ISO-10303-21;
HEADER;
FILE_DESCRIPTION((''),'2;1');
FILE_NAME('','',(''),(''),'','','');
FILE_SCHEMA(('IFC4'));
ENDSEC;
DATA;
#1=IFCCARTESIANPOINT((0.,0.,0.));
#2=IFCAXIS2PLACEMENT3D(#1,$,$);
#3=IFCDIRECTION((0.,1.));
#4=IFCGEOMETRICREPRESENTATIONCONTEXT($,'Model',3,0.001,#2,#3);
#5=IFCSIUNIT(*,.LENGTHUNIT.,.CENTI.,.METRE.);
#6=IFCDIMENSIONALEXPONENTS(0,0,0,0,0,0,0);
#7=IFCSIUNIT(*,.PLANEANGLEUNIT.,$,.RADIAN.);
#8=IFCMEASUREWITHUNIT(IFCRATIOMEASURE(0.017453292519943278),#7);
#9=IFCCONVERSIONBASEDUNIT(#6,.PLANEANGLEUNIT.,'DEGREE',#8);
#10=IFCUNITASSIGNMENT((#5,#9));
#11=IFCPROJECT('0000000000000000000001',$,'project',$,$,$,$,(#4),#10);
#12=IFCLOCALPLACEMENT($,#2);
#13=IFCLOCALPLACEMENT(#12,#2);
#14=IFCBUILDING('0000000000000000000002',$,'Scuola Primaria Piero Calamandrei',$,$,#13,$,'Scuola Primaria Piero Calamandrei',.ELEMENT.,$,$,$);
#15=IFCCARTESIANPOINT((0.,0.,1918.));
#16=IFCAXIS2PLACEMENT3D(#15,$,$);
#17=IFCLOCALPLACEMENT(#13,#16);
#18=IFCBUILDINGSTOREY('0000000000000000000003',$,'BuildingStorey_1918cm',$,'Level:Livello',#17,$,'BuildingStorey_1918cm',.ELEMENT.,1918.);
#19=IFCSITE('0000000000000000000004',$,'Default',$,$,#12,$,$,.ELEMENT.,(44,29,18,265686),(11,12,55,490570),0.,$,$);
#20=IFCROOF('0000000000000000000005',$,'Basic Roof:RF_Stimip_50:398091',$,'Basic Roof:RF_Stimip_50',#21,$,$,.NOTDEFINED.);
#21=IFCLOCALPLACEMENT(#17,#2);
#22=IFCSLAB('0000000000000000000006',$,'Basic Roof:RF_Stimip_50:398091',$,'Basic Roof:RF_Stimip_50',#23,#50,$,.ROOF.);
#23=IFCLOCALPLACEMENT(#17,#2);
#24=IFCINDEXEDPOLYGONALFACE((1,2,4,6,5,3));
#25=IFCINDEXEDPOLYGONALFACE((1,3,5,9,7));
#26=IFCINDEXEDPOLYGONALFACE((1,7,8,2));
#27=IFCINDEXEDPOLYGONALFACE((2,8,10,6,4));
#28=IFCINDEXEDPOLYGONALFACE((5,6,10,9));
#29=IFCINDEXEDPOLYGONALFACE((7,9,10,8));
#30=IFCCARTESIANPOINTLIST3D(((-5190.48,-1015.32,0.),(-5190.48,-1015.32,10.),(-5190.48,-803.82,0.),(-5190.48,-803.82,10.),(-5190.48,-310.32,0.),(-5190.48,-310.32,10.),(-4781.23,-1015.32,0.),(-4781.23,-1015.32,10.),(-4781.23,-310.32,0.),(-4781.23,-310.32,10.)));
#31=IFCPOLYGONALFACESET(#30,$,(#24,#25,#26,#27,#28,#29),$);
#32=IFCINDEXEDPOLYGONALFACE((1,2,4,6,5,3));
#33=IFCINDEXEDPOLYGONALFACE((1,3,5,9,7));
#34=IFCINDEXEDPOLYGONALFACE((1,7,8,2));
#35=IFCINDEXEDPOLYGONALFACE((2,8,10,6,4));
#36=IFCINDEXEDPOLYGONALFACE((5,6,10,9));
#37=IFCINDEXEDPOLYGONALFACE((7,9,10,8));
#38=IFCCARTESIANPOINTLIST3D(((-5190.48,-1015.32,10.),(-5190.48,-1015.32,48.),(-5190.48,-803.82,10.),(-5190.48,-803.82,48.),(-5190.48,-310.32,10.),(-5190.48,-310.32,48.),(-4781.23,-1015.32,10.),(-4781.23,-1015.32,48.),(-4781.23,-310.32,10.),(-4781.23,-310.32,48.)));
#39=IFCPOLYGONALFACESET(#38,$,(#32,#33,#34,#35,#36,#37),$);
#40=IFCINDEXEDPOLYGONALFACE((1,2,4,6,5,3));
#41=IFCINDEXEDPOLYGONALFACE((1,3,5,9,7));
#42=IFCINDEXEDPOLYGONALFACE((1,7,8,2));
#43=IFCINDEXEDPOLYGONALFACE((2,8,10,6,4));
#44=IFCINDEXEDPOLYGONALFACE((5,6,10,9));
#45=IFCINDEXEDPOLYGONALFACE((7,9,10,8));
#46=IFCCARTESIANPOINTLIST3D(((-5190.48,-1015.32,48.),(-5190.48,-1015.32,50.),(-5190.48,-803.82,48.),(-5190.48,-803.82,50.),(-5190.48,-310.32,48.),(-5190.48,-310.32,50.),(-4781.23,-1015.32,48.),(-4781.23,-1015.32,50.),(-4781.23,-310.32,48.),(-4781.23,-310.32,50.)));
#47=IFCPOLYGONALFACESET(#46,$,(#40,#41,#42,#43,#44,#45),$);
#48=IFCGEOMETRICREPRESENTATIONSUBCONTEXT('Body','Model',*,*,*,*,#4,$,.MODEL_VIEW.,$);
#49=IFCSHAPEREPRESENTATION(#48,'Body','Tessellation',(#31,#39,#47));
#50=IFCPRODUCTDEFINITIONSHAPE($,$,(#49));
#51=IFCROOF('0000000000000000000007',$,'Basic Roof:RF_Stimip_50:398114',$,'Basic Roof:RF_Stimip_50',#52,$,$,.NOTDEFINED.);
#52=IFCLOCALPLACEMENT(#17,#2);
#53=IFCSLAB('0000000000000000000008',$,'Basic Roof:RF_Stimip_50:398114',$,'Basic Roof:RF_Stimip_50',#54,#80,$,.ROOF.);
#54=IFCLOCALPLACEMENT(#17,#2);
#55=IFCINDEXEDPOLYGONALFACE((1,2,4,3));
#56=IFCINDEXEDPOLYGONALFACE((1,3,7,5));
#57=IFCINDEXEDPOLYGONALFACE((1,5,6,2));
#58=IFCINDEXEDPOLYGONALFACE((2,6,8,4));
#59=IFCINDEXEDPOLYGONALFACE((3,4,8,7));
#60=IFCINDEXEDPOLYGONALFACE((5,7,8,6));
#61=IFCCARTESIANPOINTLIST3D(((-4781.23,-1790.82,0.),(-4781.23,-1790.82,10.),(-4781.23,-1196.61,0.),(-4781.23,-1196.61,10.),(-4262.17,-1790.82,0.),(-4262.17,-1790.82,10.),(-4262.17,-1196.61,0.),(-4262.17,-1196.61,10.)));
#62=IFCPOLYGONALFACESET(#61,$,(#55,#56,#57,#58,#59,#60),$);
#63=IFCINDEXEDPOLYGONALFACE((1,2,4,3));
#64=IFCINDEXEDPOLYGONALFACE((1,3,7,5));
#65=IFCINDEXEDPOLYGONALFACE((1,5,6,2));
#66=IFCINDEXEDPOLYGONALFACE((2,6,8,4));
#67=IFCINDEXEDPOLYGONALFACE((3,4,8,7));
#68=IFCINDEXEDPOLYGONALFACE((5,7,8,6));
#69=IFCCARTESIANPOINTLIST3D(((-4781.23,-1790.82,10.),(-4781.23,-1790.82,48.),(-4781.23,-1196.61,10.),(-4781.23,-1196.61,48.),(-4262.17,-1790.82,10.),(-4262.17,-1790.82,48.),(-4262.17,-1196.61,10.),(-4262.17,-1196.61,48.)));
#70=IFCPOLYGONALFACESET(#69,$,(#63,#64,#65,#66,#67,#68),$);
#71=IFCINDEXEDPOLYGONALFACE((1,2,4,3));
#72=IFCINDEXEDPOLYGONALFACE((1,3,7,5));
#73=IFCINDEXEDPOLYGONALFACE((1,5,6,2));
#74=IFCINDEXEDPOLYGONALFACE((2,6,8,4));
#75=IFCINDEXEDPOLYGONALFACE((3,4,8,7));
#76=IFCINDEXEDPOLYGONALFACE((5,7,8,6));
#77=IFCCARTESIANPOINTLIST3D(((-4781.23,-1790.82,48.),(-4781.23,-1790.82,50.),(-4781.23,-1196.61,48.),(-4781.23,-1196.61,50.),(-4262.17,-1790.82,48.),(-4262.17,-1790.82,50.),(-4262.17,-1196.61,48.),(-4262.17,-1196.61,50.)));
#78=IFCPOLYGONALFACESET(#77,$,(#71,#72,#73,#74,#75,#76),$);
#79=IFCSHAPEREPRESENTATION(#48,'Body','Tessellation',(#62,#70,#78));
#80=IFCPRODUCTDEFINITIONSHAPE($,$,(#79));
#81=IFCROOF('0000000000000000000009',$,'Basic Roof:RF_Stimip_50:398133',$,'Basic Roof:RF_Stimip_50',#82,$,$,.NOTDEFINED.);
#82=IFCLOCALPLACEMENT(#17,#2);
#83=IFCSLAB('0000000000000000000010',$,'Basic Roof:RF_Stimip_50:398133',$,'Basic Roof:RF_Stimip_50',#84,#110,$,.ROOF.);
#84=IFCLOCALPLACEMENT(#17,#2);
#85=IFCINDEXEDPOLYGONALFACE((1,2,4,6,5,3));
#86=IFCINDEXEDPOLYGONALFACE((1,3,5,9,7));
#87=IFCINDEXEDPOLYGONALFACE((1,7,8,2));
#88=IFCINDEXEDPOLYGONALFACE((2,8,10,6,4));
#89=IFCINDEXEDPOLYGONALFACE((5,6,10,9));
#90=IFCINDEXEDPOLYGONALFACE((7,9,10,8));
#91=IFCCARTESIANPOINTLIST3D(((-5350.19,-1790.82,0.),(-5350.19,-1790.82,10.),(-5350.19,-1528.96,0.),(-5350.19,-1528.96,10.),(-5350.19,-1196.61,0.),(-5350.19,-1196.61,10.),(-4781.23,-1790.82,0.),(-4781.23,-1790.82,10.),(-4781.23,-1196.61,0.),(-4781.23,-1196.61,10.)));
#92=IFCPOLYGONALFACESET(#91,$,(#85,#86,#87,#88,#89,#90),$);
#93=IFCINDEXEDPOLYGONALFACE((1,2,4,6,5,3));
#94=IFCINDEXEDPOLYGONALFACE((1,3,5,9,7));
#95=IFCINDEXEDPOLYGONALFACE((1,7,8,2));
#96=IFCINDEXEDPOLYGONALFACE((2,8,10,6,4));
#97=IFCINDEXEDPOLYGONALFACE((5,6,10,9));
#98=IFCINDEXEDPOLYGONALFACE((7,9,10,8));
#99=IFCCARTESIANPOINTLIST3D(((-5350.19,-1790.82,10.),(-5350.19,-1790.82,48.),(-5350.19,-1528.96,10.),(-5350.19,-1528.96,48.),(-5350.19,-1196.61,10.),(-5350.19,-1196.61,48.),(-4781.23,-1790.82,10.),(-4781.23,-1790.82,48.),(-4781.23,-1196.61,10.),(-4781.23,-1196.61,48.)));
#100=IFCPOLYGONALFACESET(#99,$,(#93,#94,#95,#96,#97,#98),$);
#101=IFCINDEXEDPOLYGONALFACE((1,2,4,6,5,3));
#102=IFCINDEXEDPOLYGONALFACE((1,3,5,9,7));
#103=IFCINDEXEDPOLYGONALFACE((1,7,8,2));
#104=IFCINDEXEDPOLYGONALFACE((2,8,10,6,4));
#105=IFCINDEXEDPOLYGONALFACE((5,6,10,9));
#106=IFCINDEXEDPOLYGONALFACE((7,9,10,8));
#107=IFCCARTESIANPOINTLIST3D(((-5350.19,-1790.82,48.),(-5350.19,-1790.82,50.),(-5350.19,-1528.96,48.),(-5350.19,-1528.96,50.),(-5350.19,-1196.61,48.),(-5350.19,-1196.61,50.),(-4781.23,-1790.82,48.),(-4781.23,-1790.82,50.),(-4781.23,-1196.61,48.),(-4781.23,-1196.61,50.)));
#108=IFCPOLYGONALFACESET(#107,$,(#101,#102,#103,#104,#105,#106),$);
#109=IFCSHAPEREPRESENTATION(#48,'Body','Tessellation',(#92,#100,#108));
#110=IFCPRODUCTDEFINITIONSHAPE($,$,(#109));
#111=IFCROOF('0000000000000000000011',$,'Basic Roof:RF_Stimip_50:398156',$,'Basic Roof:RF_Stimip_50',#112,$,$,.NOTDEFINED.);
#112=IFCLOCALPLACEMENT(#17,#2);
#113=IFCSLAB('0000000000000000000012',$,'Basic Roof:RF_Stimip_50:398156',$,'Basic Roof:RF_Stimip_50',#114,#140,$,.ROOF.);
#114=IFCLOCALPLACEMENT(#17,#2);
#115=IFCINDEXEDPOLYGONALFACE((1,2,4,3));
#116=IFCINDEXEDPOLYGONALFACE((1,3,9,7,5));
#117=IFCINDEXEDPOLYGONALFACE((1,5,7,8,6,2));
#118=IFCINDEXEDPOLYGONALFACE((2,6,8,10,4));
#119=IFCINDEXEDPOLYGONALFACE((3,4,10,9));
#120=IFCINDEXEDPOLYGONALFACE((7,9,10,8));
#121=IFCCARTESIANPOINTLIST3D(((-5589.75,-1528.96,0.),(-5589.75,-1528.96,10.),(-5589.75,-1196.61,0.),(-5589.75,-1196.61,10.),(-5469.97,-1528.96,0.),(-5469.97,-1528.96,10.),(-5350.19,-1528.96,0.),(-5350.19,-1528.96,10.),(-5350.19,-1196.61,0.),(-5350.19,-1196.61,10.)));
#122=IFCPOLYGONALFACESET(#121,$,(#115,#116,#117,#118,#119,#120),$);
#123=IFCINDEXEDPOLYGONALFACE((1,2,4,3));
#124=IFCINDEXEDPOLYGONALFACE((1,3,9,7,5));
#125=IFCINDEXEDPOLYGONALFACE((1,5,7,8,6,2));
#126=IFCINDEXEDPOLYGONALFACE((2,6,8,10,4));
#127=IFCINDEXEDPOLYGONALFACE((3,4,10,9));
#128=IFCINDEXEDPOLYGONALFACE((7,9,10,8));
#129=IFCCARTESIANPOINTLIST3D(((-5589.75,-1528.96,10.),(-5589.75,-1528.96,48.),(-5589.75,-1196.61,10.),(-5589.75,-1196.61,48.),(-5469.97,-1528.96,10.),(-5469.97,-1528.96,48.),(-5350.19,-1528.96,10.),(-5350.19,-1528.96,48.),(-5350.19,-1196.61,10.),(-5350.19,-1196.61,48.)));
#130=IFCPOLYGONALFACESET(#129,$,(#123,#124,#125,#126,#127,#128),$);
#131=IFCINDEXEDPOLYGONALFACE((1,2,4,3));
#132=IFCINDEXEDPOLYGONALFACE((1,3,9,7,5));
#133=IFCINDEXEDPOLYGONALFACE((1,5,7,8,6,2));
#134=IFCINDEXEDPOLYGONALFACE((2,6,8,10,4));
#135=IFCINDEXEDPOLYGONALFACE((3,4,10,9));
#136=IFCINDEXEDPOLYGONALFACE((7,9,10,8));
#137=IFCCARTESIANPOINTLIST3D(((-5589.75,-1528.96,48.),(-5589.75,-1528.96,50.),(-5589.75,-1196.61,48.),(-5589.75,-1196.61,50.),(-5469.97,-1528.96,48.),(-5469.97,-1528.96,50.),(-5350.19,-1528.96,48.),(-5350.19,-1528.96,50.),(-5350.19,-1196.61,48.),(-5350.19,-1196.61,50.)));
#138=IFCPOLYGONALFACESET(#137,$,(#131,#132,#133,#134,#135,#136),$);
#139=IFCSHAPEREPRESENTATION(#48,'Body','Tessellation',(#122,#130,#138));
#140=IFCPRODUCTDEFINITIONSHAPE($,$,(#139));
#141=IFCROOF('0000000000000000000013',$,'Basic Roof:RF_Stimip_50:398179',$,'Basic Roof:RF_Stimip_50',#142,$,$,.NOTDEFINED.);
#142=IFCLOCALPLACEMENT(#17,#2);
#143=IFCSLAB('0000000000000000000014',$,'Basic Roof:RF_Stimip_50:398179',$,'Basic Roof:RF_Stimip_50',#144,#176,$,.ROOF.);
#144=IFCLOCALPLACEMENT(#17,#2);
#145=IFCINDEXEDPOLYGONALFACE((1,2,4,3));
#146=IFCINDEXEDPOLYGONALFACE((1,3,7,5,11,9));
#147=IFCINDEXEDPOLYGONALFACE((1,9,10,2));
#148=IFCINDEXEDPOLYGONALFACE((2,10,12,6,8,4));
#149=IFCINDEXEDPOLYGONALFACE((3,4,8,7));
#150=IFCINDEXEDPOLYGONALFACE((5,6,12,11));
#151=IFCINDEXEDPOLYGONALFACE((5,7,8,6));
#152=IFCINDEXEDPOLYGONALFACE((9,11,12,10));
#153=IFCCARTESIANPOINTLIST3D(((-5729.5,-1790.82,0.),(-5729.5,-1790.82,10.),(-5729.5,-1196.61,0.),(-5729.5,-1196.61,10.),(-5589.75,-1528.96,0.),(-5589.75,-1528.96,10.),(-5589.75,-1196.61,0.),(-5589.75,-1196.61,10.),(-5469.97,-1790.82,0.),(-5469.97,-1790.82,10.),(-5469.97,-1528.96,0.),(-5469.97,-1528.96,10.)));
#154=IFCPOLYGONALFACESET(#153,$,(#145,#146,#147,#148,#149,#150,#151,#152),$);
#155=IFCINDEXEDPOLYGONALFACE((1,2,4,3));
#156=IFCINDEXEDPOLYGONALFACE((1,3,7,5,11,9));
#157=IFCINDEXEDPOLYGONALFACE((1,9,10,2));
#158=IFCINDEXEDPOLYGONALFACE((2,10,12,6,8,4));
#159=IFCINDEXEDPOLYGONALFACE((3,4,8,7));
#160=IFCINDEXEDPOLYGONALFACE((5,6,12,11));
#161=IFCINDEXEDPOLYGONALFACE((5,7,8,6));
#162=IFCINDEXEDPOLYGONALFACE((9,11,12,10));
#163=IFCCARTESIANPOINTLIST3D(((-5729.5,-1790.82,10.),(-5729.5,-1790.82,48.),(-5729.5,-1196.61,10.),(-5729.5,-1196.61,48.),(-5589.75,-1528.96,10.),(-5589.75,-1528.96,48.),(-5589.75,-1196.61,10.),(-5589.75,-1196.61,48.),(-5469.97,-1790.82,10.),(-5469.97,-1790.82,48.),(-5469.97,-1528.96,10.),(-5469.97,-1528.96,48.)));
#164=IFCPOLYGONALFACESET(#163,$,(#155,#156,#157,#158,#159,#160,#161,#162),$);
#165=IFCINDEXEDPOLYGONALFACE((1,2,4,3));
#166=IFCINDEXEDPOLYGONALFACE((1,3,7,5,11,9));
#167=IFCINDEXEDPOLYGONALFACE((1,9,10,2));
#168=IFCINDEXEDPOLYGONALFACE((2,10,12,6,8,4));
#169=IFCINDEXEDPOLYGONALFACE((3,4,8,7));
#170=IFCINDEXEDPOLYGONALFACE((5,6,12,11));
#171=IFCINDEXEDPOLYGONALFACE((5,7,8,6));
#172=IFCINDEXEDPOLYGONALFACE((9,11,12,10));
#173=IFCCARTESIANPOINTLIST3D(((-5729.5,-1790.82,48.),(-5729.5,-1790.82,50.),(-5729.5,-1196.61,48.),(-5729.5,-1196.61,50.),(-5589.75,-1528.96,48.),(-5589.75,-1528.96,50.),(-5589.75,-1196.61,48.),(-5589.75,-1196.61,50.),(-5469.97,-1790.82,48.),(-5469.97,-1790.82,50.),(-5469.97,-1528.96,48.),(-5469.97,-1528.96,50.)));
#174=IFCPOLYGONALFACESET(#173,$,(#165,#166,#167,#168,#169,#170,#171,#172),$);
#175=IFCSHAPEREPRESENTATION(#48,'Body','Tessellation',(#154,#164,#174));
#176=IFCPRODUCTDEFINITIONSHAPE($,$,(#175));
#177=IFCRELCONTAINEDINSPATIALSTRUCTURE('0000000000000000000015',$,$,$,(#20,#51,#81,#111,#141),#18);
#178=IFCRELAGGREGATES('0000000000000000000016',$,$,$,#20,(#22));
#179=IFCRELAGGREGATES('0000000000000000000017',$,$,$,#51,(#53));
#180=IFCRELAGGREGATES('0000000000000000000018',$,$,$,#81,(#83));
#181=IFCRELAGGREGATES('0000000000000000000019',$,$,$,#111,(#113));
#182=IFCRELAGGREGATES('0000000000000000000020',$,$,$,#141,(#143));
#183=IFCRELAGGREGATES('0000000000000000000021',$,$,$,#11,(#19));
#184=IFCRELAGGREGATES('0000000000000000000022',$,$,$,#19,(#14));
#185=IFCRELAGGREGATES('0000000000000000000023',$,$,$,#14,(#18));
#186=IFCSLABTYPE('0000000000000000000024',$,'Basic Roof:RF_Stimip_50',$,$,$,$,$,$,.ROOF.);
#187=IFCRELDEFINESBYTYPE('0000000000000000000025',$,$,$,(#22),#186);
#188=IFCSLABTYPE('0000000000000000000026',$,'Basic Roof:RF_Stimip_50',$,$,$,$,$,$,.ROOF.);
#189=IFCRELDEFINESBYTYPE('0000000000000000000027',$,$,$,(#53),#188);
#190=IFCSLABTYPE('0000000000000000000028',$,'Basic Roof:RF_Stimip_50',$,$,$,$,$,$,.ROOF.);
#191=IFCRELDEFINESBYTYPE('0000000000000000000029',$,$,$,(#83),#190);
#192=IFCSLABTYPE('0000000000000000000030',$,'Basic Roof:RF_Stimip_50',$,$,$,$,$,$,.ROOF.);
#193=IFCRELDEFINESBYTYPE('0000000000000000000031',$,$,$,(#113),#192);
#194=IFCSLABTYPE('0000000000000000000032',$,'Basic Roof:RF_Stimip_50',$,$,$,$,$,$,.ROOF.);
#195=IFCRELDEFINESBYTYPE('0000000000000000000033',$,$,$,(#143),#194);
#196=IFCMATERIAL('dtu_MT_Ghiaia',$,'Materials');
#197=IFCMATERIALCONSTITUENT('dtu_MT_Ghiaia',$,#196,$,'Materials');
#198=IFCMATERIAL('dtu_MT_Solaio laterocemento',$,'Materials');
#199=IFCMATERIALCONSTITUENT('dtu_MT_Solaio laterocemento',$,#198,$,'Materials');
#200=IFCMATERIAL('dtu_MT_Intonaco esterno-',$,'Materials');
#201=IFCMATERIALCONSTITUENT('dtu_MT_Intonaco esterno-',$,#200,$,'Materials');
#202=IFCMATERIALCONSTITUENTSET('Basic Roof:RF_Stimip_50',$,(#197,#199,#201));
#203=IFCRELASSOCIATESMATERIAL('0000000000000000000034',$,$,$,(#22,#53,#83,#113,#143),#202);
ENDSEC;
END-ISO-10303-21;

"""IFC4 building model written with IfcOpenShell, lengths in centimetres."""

from ifc_helpers import new_model, entity, si_unit, converted_unit, direction, frame, origin, place, context, subcontext, project, spatial, indexed_curve, outline, extrude, material, constituent, constituent_set, type_object, element, aggregate, save


model = new_model("IFC4")

# Units and contexts
model_context = context("Model", 3, precision=0.001, world=origin(), true_north=direction((0.0, 1.0)))
body_context = subcontext(model_context, "Body", "Model", "MODEL_VIEW")
ifc_project = project(units=[si_unit("LENGTHUNIT", "METRE", prefix="CENTI"), converted_unit("PLANEANGLEUNIT", "DEGREE", entity("IfcRatioMeasure", 0.017453292519943278), si_unit("PLANEANGLEUNIT", "RADIAN"), dimensions=[0, 0, 0, 0, 0, 0, 0])], contexts=[model_context])

# Site, building, storey
site_placement = place(None, origin())
site = spatial("IfcSite", under=ifc_project, at=site_placement, Name="Default", CompositionType="ELEMENT", RefLatitude=(44, 29, 18, 265686), RefLongitude=(11, 12, 55, 490570), RefElevation=0.0)
building_placement = place(site_placement, origin())
building = spatial("IfcBuilding", under=site, at=building_placement, Name="Scuola Primaria Piero Calamandrei", LongName="Scuola Primaria Piero Calamandrei", CompositionType="ELEMENT")
storey_placement = place(building_placement, frame((0.0, 0.0, 1918.0)))
storey = spatial("IfcBuildingStorey", under=building, at=storey_placement, Name="BuildingStorey_1918cm", ObjectType="Level:Livello", LongName="BuildingStorey_1918cm", CompositionType="ELEMENT", Elevation=1918.0)

# Roofs, slabs
ifc_material_1 = material(Name="dtu_MT_Ghiaia", Category="Materials")
ifc_constituent_1 = constituent(ifc_material_1, Name="dtu_MT_Ghiaia", Category="Materials")
ifc_material_2 = material(Name="dtu_MT_Solaio laterocemento", Category="Materials")
ifc_constituent_2 = constituent(ifc_material_2, Name="dtu_MT_Solaio laterocemento", Category="Materials")
ifc_material_3 = material(Name="dtu_MT_Intonaco esterno-", Category="Materials")
ifc_constituent_3 = constituent(ifc_material_3, Name="dtu_MT_Intonaco esterno-", Category="Materials")
ifc_constituent_set = constituent_set(constituents=[ifc_constituent_1, ifc_constituent_2, ifc_constituent_3], Name="Basic Roof:RF_Stimip_50")
roof_1_placement = place(storey_placement, frame((-5190.48, -1015.32, 0.0)))
roof_1 = element("IfcRoof", 1, at=roof_1_placement, inside=storey, Name="Basic Roof:RF_Stimip_50:398091", ObjectType="Basic Roof:RF_Stimip_50", PredefinedType="NOTDEFINED")
slab_type_1 = type_object("IfcSlabType", Name="Basic Roof:RF_Stimip_50", PredefinedType="ROOF")
slab_1_placement = place(roof_1_placement, origin())
slab_1 = element("IfcSlab", 2, at=slab_1_placement, type_object=slab_type_1, material=ifc_constituent_set, Name="Basic Roof:RF_Stimip_50:398091", ObjectType="Basic Roof:RF_Stimip_50", PredefinedType="ROOF", context=body_context, shape_type="SweptSolid", body=[
    extrude(outline(indexed_curve([(-204.63, -141.0), (-204.63, -352.5), (204.63, -352.5), (204.63, 352.5), (-204.63, 352.5), (-204.63, -141.0)], self_intersect=False)), frame((204.63, 352.5, 0.0)), (0.0, 0.0, 1.0), 10.0),
    extrude(outline(indexed_curve([(-204.63, -141.0), (-204.63, -352.5), (204.63, -352.5), (204.63, 352.5), (-204.63, 352.5), (-204.63, -141.0)], self_intersect=False)), frame((204.63, 352.5, 10.0)), (0.0, 0.0, 1.0), 38.0),
    extrude(outline(indexed_curve([(-204.63, -141.0), (-204.63, -352.5), (204.63, -352.5), (204.63, 352.5), (-204.63, 352.5), (-204.63, -141.0)], self_intersect=False)), frame((204.63, 352.5, 48.0)), (0.0, 0.0, 1.0), 2.0),
])
aggregate(roof_1, [slab_1])
roof_2_placement = place(storey_placement, frame((-4781.23, -1790.82, 0.0)))
roof_2 = element("IfcRoof", 3, at=roof_2_placement, inside=storey, Name="Basic Roof:RF_Stimip_50:398114", ObjectType="Basic Roof:RF_Stimip_50", PredefinedType="NOTDEFINED")
slab_type_2 = type_object("IfcSlabType", Name="Basic Roof:RF_Stimip_50", PredefinedType="ROOF")
slab_2_placement = place(roof_2_placement, origin())
slab_2 = element("IfcSlab", 4, at=slab_2_placement, type_object=slab_type_2, material=ifc_constituent_set, Name="Basic Roof:RF_Stimip_50:398114", ObjectType="Basic Roof:RF_Stimip_50", PredefinedType="ROOF", context=body_context, shape_type="SweptSolid", body=[
    extrude(outline(indexed_curve([(-259.53, -297.11), (259.53, -297.11), (259.53, 297.11), (-259.53, 297.11), (-259.53, -297.11)], self_intersect=False)), frame((259.53, 297.11, 0.0)), (0.0, 0.0, 1.0), 10.0),
    extrude(outline(indexed_curve([(-259.53, -297.11), (259.53, -297.11), (259.53, 297.11), (-259.53, 297.11), (-259.53, -297.11)], self_intersect=False)), frame((259.53, 297.11, 10.0)), (0.0, 0.0, 1.0), 38.0),
    extrude(outline(indexed_curve([(-259.53, -297.11), (259.53, -297.11), (259.53, 297.11), (-259.53, 297.11), (-259.53, -297.11)], self_intersect=False)), frame((259.53, 297.11, 48.0)), (0.0, 0.0, 1.0), 2.0),
])
aggregate(roof_2, [slab_2])
roof_3_placement = place(storey_placement, frame((-5350.19, -1790.82, 0.0)))
roof_3 = element("IfcRoof", 5, at=roof_3_placement, inside=storey, Name="Basic Roof:RF_Stimip_50:398133", ObjectType="Basic Roof:RF_Stimip_50", PredefinedType="NOTDEFINED")
slab_type_3 = type_object("IfcSlabType", Name="Basic Roof:RF_Stimip_50", PredefinedType="ROOF")
slab_3_placement = place(roof_3_placement, origin())
slab_3 = element("IfcSlab", 6, at=slab_3_placement, type_object=slab_type_3, material=ifc_constituent_set, Name="Basic Roof:RF_Stimip_50:398133", ObjectType="Basic Roof:RF_Stimip_50", PredefinedType="ROOF", context=body_context, shape_type="SweptSolid", body=[
    extrude(outline(indexed_curve([(-284.48, -297.11), (284.48, -297.11), (284.48, 297.11), (-284.48, 297.11), (-284.48, -35.25), (-284.48, -297.11)], self_intersect=False)), frame((284.48, 297.11, 0.0)), (0.0, 0.0, 1.0), 10.0),
    extrude(outline(indexed_curve([(-284.48, -297.11), (284.48, -297.11), (284.48, 297.11), (-284.48, 297.11), (-284.48, -35.25), (-284.48, -297.11)], self_intersect=False)), frame((284.48, 297.11, 10.0)), (0.0, 0.0, 1.0), 38.0),
    extrude(outline(indexed_curve([(-284.48, -297.11), (284.48, -297.11), (284.48, 297.11), (-284.48, 297.11), (-284.48, -35.25), (-284.48, -297.11)], self_intersect=False)), frame((284.48, 297.11, 48.0)), (0.0, 0.0, 1.0), 2.0),
])
aggregate(roof_3, [slab_3])
roof_4_placement = place(storey_placement, frame((-5589.75, -1528.96, 0.0)))
roof_4 = element("IfcRoof", 7, at=roof_4_placement, inside=storey, Name="Basic Roof:RF_Stimip_50:398156", ObjectType="Basic Roof:RF_Stimip_50", PredefinedType="NOTDEFINED")
slab_type_4 = type_object("IfcSlabType", Name="Basic Roof:RF_Stimip_50", PredefinedType="ROOF")
slab_4_placement = place(roof_4_placement, origin())
slab_4 = element("IfcSlab", 8, at=slab_4_placement, type_object=slab_type_4, material=ifc_constituent_set, Name="Basic Roof:RF_Stimip_50:398156", ObjectType="Basic Roof:RF_Stimip_50", PredefinedType="ROOF", context=body_context, shape_type="SweptSolid", body=[
    extrude(outline(indexed_curve([(-119.78, -166.18), (0.0, -166.18), (119.78, -166.18), (119.78, 166.18), (-119.78, 166.18), (-119.78, -166.18)], self_intersect=False)), frame((119.78, 166.18, 0.0)), (0.0, 0.0, 1.0), 10.0),
    extrude(outline(indexed_curve([(-119.78, -166.18), (0.0, -166.18), (119.78, -166.18), (119.78, 166.18), (-119.78, 166.18), (-119.78, -166.18)], self_intersect=False)), frame((119.78, 166.18, 10.0)), (0.0, 0.0, 1.0), 38.0),
    extrude(outline(indexed_curve([(-119.78, -166.18), (0.0, -166.18), (119.78, -166.18), (119.78, 166.18), (-119.78, 166.18), (-119.78, -166.18)], self_intersect=False)), frame((119.78, 166.18, 48.0)), (0.0, 0.0, 1.0), 2.0),
])
aggregate(roof_4, [slab_4])
roof_5_placement = place(storey_placement, frame((-5729.5, -1790.82, 0.0)))
roof_5 = element("IfcRoof", 9, at=roof_5_placement, inside=storey, Name="Basic Roof:RF_Stimip_50:398179", ObjectType="Basic Roof:RF_Stimip_50", PredefinedType="NOTDEFINED")
slab_type_5 = type_object("IfcSlabType", Name="Basic Roof:RF_Stimip_50", PredefinedType="ROOF")
slab_5_placement = place(roof_5_placement, origin())
slab_5 = element("IfcSlab", 10, at=slab_5_placement, type_object=slab_type_5, material=ifc_constituent_set, Name="Basic Roof:RF_Stimip_50:398179", ObjectType="Basic Roof:RF_Stimip_50", PredefinedType="ROOF", context=body_context, shape_type="SweptSolid", body=[
    extrude(outline(indexed_curve([(-129.76, -297.11), (129.76, -297.11), (129.76, -35.25), (9.98, -35.25), (9.98, 297.11), (-129.76, 297.11), (-129.76, -297.11)], self_intersect=False)), frame((129.76, 297.11, 0.0)), (0.0, 0.0, 1.0), 10.0),
    extrude(outline(indexed_curve([(-129.76, -297.11), (129.76, -297.11), (129.76, -35.25), (9.98, -35.25), (9.98, 297.11), (-129.76, 297.11), (-129.76, -297.11)], self_intersect=False)), frame((129.76, 297.11, 10.0)), (0.0, 0.0, 1.0), 38.0),
    extrude(outline(indexed_curve([(-129.76, -297.11), (129.76, -297.11), (129.76, -35.25), (9.98, -35.25), (9.98, 297.11), (-129.76, 297.11), (-129.76, -297.11)], self_intersect=False)), frame((129.76, 297.11, 48.0)), (0.0, 0.0, 1.0), 2.0),
])
aggregate(roof_5, [slab_5])

save(model, "model.ifc")
